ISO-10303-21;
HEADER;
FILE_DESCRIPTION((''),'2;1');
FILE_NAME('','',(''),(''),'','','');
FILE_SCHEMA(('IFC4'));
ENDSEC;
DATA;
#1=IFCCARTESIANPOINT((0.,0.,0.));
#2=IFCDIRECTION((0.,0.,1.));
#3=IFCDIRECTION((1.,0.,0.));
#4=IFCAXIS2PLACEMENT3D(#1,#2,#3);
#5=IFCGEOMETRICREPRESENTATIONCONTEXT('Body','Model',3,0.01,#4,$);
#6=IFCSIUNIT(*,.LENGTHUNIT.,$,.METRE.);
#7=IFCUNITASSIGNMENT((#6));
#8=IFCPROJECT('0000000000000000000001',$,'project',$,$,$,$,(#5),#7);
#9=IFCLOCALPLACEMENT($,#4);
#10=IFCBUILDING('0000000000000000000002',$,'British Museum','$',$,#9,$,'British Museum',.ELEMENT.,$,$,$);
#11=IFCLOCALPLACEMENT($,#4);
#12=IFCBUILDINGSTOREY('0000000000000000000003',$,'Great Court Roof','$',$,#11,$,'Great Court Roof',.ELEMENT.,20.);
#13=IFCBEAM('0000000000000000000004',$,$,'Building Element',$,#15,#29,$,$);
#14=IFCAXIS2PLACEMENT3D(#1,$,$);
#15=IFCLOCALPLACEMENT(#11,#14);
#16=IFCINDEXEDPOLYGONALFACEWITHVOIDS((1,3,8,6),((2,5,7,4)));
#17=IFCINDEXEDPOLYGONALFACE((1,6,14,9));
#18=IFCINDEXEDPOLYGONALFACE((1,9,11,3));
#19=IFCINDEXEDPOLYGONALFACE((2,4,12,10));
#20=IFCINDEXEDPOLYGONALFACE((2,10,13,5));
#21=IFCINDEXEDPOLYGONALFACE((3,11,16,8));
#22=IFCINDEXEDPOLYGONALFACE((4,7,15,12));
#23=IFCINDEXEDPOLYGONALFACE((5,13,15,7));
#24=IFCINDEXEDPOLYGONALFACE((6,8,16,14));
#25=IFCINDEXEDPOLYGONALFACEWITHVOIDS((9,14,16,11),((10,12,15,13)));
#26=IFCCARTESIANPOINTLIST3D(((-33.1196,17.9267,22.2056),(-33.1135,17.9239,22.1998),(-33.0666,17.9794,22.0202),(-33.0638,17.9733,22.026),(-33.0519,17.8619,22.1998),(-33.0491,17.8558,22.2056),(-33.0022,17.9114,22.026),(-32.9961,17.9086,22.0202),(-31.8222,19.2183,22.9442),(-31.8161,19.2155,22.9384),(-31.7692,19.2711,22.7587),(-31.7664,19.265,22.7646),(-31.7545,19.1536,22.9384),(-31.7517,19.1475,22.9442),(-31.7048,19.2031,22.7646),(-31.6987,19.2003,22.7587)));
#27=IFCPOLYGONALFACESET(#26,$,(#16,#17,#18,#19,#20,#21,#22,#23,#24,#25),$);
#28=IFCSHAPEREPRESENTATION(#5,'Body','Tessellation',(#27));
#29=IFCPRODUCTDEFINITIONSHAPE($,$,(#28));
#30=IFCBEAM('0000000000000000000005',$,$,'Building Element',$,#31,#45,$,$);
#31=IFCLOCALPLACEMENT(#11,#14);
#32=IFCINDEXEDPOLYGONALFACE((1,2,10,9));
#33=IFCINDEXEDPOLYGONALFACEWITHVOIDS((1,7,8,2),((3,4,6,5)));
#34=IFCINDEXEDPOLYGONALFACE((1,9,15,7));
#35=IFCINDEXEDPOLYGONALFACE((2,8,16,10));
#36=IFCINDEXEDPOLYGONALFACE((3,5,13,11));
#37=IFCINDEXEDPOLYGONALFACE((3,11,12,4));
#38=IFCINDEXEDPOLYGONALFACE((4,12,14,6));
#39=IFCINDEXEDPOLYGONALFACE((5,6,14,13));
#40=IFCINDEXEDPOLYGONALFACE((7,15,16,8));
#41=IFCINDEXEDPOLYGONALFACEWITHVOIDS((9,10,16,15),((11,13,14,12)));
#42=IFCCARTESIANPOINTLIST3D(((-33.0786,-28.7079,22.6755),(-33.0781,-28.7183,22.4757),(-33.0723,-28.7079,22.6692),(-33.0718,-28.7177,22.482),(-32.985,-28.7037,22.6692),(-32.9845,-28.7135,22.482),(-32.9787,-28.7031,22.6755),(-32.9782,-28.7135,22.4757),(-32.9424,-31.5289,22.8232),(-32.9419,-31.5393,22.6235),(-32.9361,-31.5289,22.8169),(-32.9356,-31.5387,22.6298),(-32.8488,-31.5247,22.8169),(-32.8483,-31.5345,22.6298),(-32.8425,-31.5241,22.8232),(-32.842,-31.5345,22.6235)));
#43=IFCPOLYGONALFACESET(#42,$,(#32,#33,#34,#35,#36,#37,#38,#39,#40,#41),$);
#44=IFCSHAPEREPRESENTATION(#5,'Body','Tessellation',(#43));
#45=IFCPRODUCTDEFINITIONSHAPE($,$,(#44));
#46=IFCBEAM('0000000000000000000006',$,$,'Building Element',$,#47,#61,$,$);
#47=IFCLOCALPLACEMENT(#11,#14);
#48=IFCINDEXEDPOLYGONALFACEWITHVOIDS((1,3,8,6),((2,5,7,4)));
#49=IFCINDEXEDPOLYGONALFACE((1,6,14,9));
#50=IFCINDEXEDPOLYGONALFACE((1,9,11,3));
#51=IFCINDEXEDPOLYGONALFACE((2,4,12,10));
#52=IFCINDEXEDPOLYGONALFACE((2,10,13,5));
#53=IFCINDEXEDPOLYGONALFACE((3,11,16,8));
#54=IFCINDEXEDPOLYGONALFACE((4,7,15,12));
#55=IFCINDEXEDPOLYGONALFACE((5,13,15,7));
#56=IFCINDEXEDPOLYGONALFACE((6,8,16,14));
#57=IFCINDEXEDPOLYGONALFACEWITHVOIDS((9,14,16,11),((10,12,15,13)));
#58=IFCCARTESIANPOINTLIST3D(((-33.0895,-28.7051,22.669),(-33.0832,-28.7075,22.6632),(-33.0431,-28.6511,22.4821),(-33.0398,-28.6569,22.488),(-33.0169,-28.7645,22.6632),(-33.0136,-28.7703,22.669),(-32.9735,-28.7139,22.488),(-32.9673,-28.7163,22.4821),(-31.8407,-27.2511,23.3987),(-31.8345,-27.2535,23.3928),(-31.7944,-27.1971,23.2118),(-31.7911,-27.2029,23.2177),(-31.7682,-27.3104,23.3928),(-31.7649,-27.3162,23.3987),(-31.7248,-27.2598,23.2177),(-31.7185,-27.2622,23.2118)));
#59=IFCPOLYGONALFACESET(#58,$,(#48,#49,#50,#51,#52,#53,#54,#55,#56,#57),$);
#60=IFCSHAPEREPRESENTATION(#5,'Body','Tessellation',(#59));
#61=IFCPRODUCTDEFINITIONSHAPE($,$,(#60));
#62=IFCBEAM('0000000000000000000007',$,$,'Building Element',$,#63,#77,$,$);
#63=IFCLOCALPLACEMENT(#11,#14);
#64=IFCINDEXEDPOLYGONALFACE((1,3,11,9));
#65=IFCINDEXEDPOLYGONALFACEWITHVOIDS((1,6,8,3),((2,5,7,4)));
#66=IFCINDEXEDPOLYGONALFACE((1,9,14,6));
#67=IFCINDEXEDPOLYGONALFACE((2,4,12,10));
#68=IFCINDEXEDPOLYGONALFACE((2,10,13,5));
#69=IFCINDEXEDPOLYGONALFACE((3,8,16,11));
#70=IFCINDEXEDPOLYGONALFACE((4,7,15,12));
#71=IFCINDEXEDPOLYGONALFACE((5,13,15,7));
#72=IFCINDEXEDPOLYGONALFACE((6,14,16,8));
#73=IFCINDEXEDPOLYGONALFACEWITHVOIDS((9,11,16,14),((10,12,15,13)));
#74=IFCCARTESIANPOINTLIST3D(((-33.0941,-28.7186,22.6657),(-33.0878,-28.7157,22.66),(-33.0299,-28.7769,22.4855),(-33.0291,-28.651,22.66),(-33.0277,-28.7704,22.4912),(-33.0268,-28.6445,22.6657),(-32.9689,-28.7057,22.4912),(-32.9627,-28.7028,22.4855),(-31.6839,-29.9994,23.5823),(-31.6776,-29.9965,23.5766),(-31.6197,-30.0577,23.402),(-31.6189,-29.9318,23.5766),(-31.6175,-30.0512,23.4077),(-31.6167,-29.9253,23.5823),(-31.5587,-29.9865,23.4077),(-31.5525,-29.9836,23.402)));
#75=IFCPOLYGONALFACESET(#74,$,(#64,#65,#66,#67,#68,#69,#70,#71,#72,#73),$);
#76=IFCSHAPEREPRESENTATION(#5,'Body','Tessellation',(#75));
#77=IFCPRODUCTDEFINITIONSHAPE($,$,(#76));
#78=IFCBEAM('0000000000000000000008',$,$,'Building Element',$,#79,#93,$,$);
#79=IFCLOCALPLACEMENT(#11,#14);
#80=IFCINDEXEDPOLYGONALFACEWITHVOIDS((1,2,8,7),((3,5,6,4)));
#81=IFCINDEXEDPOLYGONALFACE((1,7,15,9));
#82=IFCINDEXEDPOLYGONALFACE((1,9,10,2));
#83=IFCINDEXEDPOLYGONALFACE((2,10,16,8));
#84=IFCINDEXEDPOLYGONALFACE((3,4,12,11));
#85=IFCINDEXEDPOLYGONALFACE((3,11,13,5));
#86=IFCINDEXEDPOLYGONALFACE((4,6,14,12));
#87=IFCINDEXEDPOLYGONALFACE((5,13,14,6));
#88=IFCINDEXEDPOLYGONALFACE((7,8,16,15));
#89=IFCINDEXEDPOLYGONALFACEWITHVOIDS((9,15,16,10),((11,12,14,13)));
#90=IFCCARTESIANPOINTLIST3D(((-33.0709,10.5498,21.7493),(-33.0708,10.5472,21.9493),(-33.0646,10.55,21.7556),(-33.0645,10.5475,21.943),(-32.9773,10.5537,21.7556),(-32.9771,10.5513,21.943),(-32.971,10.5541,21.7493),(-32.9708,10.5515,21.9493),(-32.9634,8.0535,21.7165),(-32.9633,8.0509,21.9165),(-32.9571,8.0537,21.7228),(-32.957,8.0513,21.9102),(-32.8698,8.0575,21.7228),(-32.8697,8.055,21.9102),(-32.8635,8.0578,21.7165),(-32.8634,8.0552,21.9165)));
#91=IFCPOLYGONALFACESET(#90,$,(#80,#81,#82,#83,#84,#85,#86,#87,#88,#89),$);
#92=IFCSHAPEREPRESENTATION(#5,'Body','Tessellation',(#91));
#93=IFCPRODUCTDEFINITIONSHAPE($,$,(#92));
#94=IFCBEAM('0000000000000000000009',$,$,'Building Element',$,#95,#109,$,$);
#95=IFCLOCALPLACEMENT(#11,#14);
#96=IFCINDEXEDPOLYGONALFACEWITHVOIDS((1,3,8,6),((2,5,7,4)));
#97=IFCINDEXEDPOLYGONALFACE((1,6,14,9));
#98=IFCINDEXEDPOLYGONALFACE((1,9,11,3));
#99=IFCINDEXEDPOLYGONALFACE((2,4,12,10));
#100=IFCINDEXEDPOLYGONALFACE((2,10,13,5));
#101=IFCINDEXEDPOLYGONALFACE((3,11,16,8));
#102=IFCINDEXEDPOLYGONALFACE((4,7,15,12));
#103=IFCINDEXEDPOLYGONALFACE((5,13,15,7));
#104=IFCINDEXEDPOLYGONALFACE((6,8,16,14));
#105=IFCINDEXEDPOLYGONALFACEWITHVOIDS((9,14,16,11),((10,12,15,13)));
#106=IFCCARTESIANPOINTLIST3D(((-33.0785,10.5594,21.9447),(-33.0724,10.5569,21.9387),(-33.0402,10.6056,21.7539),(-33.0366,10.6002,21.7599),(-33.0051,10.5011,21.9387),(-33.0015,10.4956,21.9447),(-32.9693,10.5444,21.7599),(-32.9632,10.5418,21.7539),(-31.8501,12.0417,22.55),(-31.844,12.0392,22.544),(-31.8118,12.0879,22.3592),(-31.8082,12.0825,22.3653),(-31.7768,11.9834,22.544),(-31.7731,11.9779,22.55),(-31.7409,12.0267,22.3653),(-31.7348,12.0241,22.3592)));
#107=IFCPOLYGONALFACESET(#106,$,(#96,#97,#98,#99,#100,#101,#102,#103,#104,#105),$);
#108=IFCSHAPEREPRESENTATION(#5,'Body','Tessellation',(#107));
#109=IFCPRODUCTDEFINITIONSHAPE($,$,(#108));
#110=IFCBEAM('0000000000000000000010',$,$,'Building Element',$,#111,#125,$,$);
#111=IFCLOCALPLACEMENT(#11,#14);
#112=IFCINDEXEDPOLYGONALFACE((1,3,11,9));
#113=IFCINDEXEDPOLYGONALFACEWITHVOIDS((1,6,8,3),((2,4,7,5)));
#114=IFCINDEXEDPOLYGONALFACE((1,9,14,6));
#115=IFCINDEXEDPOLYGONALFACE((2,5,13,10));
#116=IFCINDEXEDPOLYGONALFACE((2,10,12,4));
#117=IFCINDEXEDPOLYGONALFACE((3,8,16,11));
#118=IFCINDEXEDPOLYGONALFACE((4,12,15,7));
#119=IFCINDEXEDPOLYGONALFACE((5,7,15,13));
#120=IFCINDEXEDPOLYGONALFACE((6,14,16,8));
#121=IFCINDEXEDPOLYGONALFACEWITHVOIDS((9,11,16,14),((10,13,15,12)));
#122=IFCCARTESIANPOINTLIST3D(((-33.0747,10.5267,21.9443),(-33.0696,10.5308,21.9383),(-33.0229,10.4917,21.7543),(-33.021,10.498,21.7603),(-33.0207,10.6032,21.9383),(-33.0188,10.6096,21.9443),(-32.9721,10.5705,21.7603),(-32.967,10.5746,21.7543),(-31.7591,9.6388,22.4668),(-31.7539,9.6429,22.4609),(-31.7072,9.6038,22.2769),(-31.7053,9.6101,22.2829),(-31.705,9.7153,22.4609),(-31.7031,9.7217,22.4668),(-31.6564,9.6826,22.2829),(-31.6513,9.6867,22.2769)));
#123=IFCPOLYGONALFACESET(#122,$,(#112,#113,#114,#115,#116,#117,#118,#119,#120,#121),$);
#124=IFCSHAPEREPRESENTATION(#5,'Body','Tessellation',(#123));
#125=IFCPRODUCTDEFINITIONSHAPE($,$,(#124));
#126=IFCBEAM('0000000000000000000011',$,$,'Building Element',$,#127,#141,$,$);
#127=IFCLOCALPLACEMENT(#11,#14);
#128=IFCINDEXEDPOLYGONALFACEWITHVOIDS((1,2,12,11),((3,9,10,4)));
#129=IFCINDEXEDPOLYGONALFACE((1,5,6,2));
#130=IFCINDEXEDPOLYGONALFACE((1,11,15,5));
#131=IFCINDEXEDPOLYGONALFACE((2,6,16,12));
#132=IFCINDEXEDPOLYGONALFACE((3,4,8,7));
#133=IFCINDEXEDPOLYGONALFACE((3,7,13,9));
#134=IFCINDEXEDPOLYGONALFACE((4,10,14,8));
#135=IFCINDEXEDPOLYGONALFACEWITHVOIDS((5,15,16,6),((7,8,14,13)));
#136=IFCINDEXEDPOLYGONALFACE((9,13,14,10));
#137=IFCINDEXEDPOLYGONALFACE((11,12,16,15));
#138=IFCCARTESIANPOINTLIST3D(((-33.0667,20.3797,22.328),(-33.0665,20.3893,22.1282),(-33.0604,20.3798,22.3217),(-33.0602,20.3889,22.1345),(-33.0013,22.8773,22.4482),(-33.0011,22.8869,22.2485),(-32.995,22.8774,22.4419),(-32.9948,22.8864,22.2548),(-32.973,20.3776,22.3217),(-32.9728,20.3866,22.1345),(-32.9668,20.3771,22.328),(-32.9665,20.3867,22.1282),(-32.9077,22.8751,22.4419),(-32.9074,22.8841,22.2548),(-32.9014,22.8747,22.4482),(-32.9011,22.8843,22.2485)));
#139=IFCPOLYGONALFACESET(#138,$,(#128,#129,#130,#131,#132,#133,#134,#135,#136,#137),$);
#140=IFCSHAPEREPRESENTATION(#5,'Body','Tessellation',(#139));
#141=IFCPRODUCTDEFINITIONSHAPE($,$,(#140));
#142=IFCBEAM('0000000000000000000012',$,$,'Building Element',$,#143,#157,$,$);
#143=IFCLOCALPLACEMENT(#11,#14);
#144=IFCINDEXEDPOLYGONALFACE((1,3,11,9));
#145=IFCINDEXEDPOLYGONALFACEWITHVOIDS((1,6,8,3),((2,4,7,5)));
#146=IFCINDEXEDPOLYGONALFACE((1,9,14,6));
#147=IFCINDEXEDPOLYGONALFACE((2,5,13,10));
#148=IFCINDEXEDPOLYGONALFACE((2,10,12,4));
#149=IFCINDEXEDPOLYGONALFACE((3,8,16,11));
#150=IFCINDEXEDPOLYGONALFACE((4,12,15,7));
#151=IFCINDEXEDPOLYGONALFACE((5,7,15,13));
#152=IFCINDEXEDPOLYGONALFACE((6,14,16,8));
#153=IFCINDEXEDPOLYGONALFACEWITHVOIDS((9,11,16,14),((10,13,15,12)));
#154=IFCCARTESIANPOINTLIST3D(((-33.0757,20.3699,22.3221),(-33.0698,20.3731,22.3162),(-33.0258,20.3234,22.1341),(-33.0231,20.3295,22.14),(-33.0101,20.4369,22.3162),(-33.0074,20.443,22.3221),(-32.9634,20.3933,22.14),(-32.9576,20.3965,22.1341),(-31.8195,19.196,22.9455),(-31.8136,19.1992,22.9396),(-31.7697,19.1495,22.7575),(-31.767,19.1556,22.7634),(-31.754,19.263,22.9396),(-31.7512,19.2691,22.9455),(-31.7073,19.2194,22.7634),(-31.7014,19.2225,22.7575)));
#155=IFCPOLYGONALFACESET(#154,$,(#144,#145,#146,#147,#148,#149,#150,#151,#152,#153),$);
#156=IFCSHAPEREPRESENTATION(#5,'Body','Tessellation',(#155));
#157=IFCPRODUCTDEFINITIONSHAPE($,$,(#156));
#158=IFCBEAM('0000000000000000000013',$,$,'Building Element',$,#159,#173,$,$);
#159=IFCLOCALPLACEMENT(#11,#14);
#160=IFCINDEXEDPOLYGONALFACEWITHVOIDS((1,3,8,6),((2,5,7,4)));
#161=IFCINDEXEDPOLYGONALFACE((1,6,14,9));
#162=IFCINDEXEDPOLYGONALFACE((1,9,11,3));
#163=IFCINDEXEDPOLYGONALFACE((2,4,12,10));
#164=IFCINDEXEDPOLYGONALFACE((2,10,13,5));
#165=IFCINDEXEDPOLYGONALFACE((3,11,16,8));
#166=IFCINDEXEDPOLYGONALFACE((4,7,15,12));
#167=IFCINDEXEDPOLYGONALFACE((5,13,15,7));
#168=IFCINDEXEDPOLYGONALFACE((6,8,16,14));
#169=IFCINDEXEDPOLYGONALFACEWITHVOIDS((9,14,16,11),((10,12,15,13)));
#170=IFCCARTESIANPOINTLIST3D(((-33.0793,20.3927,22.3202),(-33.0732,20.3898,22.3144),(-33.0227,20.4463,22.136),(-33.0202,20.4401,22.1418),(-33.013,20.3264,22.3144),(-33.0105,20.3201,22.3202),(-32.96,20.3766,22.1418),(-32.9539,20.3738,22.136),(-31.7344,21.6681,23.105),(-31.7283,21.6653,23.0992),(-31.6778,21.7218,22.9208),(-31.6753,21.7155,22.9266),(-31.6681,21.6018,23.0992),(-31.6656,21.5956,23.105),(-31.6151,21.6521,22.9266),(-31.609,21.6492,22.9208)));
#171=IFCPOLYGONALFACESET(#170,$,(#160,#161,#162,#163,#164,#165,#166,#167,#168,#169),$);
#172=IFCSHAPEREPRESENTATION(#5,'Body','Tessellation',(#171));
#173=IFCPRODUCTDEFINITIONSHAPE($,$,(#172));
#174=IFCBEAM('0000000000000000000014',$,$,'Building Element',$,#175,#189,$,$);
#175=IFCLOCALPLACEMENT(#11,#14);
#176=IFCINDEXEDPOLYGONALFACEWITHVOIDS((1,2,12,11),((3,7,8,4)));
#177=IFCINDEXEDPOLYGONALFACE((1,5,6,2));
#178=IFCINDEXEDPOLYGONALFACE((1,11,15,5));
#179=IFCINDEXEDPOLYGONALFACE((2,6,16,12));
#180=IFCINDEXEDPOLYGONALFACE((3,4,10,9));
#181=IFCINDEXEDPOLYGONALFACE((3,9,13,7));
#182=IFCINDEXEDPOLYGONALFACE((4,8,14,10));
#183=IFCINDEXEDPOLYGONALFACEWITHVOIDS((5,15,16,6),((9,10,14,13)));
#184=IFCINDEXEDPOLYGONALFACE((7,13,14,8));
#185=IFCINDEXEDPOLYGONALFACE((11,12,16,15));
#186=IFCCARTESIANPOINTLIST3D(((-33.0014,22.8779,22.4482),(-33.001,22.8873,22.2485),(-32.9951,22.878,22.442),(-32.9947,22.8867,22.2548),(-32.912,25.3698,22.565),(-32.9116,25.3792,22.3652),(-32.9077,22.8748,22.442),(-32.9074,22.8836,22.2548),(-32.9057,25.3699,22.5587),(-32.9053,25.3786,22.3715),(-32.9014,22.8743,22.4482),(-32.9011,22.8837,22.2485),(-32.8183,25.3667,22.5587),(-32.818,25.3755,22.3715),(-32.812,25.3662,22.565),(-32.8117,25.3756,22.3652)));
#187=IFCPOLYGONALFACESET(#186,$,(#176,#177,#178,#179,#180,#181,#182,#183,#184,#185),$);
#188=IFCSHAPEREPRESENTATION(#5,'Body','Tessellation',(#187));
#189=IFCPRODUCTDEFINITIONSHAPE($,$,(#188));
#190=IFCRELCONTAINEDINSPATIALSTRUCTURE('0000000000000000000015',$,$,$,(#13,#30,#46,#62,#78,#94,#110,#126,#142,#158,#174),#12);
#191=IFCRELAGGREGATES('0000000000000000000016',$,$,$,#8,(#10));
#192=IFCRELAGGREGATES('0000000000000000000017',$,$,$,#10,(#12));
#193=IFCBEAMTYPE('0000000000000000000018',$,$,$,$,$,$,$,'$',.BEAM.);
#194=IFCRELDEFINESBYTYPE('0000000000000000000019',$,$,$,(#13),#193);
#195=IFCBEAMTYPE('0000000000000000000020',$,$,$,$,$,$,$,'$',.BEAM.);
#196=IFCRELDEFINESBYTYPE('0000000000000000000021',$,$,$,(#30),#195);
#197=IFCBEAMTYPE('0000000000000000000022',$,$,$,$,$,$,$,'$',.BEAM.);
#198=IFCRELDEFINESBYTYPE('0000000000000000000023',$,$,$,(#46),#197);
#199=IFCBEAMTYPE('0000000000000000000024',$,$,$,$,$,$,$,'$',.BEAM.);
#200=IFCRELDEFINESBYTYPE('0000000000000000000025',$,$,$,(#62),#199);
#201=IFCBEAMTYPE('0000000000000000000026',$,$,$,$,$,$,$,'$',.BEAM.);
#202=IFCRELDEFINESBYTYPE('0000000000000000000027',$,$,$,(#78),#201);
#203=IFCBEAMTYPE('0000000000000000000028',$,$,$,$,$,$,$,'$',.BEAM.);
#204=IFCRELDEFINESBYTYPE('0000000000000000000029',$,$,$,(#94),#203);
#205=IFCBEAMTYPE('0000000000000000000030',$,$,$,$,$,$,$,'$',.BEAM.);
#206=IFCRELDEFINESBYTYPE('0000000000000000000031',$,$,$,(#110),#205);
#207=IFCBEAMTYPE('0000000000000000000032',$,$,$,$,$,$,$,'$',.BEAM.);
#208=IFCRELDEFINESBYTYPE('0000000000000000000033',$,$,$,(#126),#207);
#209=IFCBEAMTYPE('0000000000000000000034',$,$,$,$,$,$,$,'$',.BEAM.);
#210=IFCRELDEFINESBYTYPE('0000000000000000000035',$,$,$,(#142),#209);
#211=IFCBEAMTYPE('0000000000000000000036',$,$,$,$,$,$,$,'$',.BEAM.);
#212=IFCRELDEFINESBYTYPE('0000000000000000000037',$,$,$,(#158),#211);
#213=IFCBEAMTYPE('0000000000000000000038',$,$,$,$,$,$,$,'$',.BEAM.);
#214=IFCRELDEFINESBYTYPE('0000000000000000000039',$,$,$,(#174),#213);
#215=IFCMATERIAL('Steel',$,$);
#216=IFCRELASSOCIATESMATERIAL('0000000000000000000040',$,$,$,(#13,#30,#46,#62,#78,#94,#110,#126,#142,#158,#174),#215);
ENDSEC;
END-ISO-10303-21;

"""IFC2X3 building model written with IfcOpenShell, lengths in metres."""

from ifc_helpers import new_model, si_unit, frame, origin_with_axes, origin_2d, place, context, project, spatial, hollow_rectangle, extrude, material, type_object, element, save


model = new_model("IFC2X3")

# Units and contexts
model_context = context("Model", 3, precision=0.01, world=origin_with_axes(), identifier="Body")
ifc_project = project(units=[si_unit("LENGTHUNIT", "METRE")], contexts=[model_context])

# Building, storey
building_placement = place(None, origin_with_axes())
building = spatial("IfcBuilding", under=ifc_project, at=building_placement, Name="British Museum", Description="$", LongName="British Museum", CompositionType="ELEMENT")
storey_placement = place(None, origin_with_axes())
storey = spatial("IfcBuildingStorey", under=building, at=storey_placement, Name="Great Court Roof", Description="$", LongName="Great Court Roof", CompositionType="ELEMENT", Elevation=20.0)

# Beams
ifc_material = material(Name="Steel")
beam_type_1 = type_object("IfcBeamType", ElementType="$", PredefinedType="BEAM")
beam_1_placement = place(None, origin_with_axes())
element("IfcBeam", 1, at=beam_1_placement, inside=storey, type_object=beam_type_1, material=ifc_material, Description="Building Element", context=model_context, shape_type="SweptSolid", body=[
    extrude(hollow_rectangle(XDim=0.1, YDim=0.2, WallThickness=0.0063, InnerFilletRadius=0.0, OuterFilletRadius=0.0, at=origin_2d()), frame((-33.0579, 17.9176, 22.1129), z_axis=(0.657204, 0.654304, 0.374124), x_axis=(-0.705542, 0.708668, 0.0)), (0.0, 0.0, 1.0), 1.9741),
])
beam_type_2 = type_object("IfcBeamType", ElementType="$", PredefinedType="BEAM")
beam_2_placement = place(None, origin_with_axes())
element("IfcBeam", 2, at=beam_2_placement, inside=storey, type_object=beam_type_2, material=ifc_material, Description="Building Element", context=model_context, shape_type="SweptSolid", body=[
    extrude(hollow_rectangle(XDim=0.1, YDim=0.2, WallThickness=0.0063, InnerFilletRadius=0.0, OuterFilletRadius=0.0, at=origin_2d()), frame((-33.0284, -28.7107, 22.5756), z_axis=(0.048154, -0.997472, 0.052254), x_axis=(0.998837, 0.04822, 0.0)), (0.0, 0.0, 1.0), 2.8282),
])
beam_type_3 = type_object("IfcBeamType", ElementType="$", PredefinedType="BEAM")
beam_3_placement = place(None, origin_with_axes())
element("IfcBeam", 3, at=beam_3_placement, inside=storey, type_object=beam_type_3, material=ifc_material, Description="Building Element", context=model_context, shape_type="SweptSolid", body=[
    extrude(hollow_rectangle(XDim=0.1, YDim=0.2, WallThickness=0.0063, InnerFilletRadius=0.0, OuterFilletRadius=0.0, at=origin_2d()), frame((-33.0284, -28.7107, 22.5756), z_axis=(0.608887, 0.709, 0.355774), x_axis=(-0.758636, 0.651514, 0.0)), (0.0, 0.0, 1.0), 2.0509),
])
beam_type_4 = type_object("IfcBeamType", ElementType="$", PredefinedType="BEAM")
beam_4_placement = place(None, origin_with_axes())
element("IfcBeam", 4, at=beam_4_placement, inside=storey, type_object=beam_type_4, material=ifc_material, Description="Building Element", context=model_context, shape_type="SweptSolid", body=[
    extrude(hollow_rectangle(XDim=0.1, YDim=0.2, WallThickness=0.0063, InnerFilletRadius=0.0, OuterFilletRadius=0.0, at=origin_2d()), frame((-33.0284, -28.7107, 22.5756), z_axis=(0.667061, -0.605854, 0.433556), x_axis=(0.67233, 0.740252, 0.0)), (0.0, 0.0, 1.0), 2.114),
])
beam_type_5 = type_object("IfcBeamType", ElementType="$", PredefinedType="BEAM")
beam_5_placement = place(None, origin_with_axes())
element("IfcBeam", 5, at=beam_5_placement, inside=storey, type_object=beam_type_5, material=ifc_material, Description="Building Element", context=model_context, shape_type="SweptSolid", body=[
    extrude(hollow_rectangle(XDim=0.1, YDim=0.2, WallThickness=0.0063, InnerFilletRadius=0.0, OuterFilletRadius=0.0, at=origin_2d()), frame((-33.0209, 10.5506, 21.8493), z_axis=(0.043019, -0.998988, -0.013127), x_axis=(0.999074, 0.043022, 0.0)), (0.0, 0.0, 1.0), 2.4988),
])
beam_type_6 = type_object("IfcBeamType", ElementType="$", PredefinedType="BEAM")
beam_6_placement = place(None, origin_with_axes())
element("IfcBeam", 6, at=beam_6_placement, inside=storey, type_object=beam_type_6, material=ifc_material, Description="Building Element", context=model_context, shape_type="SweptSolid", body=[
    extrude(hollow_rectangle(XDim=0.1, YDim=0.2, WallThickness=0.0063, InnerFilletRadius=0.0, OuterFilletRadius=0.0, at=origin_2d()), frame((-33.0209, 10.5506, 21.8493), z_axis=(0.608698, 0.734513, 0.299964), x_axis=(-0.769969, 0.638081, 0.0)), (0.0, 0.0, 1.0), 2.0181),
])
beam_type_7 = type_object("IfcBeamType", ElementType="$", PredefinedType="BEAM")
beam_7_placement = place(None, origin_with_axes())
element("IfcBeam", 7, at=beam_7_placement, inside=storey, type_object=beam_type_7, material=ifc_material, Description="Building Element", context=model_context, shape_type="SweptSolid", body=[
    extrude(hollow_rectangle(XDim=0.1, YDim=0.2, WallThickness=0.0063, InnerFilletRadius=0.0, OuterFilletRadius=0.0, at=origin_2d()), frame((-33.0209, 10.5506, 21.8493), z_axis=(0.787335, -0.531331, 0.312714), x_axis=(0.559386, 0.828907, 0.0)), (0.0, 0.0, 1.0), 1.6711),
])
beam_type_8 = type_object("IfcBeamType", ElementType="$", PredefinedType="BEAM")
beam_8_placement = place(None, origin_with_axes())
element("IfcBeam", 8, at=beam_8_placement, inside=storey, type_object=beam_type_8, material=ifc_material, Description="Building Element", context=model_context, shape_type="SweptSolid", body=[
    extrude(hollow_rectangle(XDim=0.1, YDim=0.2, WallThickness=0.0063, InnerFilletRadius=0.0, OuterFilletRadius=0.0, at=origin_2d()), frame((-33.0166, 20.3832, 22.2281), z_axis=(0.02614, 0.998501, 0.04808), x_axis=(-0.999658, 0.02617, 0.0)), (0.0, 0.0, 1.0), 2.5013),
])
beam_type_9 = type_object("IfcBeamType", ElementType="$", PredefinedType="BEAM")
beam_9_placement = place(None, origin_with_axes())
element("IfcBeam", 9, at=beam_9_placement, inside=storey, type_object=beam_type_9, material=ifc_material, Description="Building Element", context=model_context, shape_type="SweptSolid", body=[
    extrude(hollow_rectangle(XDim=0.1, YDim=0.2, WallThickness=0.0063, InnerFilletRadius=0.0, OuterFilletRadius=0.0, at=origin_2d()), frame((-33.0166, 20.3832, 22.2281), z_axis=(0.686867, -0.641895, 0.340859), x_axis=(0.682784, 0.73062, 0.0)), (0.0, 0.0, 1.0), 1.8288),
])
beam_type_10 = type_object("IfcBeamType", ElementType="$", PredefinedType="BEAM")
beam_10_placement = place(None, origin_with_axes())
element("IfcBeam", 10, at=beam_10_placement, inside=storey, type_object=beam_type_10, material=ifc_material, Description="Building Element", context=model_context, shape_type="SweptSolid", body=[
    extrude(hollow_rectangle(XDim=0.1, YDim=0.2, WallThickness=0.0063, InnerFilletRadius=0.0, OuterFilletRadius=0.0, at=origin_2d()), frame((-33.0166, 20.3832, 22.2281), z_axis=(0.668161, 0.633671, 0.389899), x_axis=(-0.688132, 0.725586, 0.0)), (0.0, 0.0, 1.0), 2.0128),
])
beam_type_11 = type_object("IfcBeamType", ElementType="$", PredefinedType="BEAM")
beam_11_placement = place(None, origin_with_axes())
element("IfcBeam", 11, at=beam_11_placement, inside=storey, type_object=beam_type_11, material=ifc_material, Description="Building Element", context=model_context, shape_type="SweptSolid", body=[
    extrude(hollow_rectangle(XDim=0.1, YDim=0.2, WallThickness=0.0063, InnerFilletRadius=0.0, OuterFilletRadius=0.0, at=origin_2d()), frame((-32.9512, 22.8808, 22.3484), z_axis=(0.035812, 0.998264, 0.046762), x_axis=(-0.999357, 0.035851, 0.0)), (0.0, 0.0, 1.0), 2.4962),
])

save(model, "model.ifc")
